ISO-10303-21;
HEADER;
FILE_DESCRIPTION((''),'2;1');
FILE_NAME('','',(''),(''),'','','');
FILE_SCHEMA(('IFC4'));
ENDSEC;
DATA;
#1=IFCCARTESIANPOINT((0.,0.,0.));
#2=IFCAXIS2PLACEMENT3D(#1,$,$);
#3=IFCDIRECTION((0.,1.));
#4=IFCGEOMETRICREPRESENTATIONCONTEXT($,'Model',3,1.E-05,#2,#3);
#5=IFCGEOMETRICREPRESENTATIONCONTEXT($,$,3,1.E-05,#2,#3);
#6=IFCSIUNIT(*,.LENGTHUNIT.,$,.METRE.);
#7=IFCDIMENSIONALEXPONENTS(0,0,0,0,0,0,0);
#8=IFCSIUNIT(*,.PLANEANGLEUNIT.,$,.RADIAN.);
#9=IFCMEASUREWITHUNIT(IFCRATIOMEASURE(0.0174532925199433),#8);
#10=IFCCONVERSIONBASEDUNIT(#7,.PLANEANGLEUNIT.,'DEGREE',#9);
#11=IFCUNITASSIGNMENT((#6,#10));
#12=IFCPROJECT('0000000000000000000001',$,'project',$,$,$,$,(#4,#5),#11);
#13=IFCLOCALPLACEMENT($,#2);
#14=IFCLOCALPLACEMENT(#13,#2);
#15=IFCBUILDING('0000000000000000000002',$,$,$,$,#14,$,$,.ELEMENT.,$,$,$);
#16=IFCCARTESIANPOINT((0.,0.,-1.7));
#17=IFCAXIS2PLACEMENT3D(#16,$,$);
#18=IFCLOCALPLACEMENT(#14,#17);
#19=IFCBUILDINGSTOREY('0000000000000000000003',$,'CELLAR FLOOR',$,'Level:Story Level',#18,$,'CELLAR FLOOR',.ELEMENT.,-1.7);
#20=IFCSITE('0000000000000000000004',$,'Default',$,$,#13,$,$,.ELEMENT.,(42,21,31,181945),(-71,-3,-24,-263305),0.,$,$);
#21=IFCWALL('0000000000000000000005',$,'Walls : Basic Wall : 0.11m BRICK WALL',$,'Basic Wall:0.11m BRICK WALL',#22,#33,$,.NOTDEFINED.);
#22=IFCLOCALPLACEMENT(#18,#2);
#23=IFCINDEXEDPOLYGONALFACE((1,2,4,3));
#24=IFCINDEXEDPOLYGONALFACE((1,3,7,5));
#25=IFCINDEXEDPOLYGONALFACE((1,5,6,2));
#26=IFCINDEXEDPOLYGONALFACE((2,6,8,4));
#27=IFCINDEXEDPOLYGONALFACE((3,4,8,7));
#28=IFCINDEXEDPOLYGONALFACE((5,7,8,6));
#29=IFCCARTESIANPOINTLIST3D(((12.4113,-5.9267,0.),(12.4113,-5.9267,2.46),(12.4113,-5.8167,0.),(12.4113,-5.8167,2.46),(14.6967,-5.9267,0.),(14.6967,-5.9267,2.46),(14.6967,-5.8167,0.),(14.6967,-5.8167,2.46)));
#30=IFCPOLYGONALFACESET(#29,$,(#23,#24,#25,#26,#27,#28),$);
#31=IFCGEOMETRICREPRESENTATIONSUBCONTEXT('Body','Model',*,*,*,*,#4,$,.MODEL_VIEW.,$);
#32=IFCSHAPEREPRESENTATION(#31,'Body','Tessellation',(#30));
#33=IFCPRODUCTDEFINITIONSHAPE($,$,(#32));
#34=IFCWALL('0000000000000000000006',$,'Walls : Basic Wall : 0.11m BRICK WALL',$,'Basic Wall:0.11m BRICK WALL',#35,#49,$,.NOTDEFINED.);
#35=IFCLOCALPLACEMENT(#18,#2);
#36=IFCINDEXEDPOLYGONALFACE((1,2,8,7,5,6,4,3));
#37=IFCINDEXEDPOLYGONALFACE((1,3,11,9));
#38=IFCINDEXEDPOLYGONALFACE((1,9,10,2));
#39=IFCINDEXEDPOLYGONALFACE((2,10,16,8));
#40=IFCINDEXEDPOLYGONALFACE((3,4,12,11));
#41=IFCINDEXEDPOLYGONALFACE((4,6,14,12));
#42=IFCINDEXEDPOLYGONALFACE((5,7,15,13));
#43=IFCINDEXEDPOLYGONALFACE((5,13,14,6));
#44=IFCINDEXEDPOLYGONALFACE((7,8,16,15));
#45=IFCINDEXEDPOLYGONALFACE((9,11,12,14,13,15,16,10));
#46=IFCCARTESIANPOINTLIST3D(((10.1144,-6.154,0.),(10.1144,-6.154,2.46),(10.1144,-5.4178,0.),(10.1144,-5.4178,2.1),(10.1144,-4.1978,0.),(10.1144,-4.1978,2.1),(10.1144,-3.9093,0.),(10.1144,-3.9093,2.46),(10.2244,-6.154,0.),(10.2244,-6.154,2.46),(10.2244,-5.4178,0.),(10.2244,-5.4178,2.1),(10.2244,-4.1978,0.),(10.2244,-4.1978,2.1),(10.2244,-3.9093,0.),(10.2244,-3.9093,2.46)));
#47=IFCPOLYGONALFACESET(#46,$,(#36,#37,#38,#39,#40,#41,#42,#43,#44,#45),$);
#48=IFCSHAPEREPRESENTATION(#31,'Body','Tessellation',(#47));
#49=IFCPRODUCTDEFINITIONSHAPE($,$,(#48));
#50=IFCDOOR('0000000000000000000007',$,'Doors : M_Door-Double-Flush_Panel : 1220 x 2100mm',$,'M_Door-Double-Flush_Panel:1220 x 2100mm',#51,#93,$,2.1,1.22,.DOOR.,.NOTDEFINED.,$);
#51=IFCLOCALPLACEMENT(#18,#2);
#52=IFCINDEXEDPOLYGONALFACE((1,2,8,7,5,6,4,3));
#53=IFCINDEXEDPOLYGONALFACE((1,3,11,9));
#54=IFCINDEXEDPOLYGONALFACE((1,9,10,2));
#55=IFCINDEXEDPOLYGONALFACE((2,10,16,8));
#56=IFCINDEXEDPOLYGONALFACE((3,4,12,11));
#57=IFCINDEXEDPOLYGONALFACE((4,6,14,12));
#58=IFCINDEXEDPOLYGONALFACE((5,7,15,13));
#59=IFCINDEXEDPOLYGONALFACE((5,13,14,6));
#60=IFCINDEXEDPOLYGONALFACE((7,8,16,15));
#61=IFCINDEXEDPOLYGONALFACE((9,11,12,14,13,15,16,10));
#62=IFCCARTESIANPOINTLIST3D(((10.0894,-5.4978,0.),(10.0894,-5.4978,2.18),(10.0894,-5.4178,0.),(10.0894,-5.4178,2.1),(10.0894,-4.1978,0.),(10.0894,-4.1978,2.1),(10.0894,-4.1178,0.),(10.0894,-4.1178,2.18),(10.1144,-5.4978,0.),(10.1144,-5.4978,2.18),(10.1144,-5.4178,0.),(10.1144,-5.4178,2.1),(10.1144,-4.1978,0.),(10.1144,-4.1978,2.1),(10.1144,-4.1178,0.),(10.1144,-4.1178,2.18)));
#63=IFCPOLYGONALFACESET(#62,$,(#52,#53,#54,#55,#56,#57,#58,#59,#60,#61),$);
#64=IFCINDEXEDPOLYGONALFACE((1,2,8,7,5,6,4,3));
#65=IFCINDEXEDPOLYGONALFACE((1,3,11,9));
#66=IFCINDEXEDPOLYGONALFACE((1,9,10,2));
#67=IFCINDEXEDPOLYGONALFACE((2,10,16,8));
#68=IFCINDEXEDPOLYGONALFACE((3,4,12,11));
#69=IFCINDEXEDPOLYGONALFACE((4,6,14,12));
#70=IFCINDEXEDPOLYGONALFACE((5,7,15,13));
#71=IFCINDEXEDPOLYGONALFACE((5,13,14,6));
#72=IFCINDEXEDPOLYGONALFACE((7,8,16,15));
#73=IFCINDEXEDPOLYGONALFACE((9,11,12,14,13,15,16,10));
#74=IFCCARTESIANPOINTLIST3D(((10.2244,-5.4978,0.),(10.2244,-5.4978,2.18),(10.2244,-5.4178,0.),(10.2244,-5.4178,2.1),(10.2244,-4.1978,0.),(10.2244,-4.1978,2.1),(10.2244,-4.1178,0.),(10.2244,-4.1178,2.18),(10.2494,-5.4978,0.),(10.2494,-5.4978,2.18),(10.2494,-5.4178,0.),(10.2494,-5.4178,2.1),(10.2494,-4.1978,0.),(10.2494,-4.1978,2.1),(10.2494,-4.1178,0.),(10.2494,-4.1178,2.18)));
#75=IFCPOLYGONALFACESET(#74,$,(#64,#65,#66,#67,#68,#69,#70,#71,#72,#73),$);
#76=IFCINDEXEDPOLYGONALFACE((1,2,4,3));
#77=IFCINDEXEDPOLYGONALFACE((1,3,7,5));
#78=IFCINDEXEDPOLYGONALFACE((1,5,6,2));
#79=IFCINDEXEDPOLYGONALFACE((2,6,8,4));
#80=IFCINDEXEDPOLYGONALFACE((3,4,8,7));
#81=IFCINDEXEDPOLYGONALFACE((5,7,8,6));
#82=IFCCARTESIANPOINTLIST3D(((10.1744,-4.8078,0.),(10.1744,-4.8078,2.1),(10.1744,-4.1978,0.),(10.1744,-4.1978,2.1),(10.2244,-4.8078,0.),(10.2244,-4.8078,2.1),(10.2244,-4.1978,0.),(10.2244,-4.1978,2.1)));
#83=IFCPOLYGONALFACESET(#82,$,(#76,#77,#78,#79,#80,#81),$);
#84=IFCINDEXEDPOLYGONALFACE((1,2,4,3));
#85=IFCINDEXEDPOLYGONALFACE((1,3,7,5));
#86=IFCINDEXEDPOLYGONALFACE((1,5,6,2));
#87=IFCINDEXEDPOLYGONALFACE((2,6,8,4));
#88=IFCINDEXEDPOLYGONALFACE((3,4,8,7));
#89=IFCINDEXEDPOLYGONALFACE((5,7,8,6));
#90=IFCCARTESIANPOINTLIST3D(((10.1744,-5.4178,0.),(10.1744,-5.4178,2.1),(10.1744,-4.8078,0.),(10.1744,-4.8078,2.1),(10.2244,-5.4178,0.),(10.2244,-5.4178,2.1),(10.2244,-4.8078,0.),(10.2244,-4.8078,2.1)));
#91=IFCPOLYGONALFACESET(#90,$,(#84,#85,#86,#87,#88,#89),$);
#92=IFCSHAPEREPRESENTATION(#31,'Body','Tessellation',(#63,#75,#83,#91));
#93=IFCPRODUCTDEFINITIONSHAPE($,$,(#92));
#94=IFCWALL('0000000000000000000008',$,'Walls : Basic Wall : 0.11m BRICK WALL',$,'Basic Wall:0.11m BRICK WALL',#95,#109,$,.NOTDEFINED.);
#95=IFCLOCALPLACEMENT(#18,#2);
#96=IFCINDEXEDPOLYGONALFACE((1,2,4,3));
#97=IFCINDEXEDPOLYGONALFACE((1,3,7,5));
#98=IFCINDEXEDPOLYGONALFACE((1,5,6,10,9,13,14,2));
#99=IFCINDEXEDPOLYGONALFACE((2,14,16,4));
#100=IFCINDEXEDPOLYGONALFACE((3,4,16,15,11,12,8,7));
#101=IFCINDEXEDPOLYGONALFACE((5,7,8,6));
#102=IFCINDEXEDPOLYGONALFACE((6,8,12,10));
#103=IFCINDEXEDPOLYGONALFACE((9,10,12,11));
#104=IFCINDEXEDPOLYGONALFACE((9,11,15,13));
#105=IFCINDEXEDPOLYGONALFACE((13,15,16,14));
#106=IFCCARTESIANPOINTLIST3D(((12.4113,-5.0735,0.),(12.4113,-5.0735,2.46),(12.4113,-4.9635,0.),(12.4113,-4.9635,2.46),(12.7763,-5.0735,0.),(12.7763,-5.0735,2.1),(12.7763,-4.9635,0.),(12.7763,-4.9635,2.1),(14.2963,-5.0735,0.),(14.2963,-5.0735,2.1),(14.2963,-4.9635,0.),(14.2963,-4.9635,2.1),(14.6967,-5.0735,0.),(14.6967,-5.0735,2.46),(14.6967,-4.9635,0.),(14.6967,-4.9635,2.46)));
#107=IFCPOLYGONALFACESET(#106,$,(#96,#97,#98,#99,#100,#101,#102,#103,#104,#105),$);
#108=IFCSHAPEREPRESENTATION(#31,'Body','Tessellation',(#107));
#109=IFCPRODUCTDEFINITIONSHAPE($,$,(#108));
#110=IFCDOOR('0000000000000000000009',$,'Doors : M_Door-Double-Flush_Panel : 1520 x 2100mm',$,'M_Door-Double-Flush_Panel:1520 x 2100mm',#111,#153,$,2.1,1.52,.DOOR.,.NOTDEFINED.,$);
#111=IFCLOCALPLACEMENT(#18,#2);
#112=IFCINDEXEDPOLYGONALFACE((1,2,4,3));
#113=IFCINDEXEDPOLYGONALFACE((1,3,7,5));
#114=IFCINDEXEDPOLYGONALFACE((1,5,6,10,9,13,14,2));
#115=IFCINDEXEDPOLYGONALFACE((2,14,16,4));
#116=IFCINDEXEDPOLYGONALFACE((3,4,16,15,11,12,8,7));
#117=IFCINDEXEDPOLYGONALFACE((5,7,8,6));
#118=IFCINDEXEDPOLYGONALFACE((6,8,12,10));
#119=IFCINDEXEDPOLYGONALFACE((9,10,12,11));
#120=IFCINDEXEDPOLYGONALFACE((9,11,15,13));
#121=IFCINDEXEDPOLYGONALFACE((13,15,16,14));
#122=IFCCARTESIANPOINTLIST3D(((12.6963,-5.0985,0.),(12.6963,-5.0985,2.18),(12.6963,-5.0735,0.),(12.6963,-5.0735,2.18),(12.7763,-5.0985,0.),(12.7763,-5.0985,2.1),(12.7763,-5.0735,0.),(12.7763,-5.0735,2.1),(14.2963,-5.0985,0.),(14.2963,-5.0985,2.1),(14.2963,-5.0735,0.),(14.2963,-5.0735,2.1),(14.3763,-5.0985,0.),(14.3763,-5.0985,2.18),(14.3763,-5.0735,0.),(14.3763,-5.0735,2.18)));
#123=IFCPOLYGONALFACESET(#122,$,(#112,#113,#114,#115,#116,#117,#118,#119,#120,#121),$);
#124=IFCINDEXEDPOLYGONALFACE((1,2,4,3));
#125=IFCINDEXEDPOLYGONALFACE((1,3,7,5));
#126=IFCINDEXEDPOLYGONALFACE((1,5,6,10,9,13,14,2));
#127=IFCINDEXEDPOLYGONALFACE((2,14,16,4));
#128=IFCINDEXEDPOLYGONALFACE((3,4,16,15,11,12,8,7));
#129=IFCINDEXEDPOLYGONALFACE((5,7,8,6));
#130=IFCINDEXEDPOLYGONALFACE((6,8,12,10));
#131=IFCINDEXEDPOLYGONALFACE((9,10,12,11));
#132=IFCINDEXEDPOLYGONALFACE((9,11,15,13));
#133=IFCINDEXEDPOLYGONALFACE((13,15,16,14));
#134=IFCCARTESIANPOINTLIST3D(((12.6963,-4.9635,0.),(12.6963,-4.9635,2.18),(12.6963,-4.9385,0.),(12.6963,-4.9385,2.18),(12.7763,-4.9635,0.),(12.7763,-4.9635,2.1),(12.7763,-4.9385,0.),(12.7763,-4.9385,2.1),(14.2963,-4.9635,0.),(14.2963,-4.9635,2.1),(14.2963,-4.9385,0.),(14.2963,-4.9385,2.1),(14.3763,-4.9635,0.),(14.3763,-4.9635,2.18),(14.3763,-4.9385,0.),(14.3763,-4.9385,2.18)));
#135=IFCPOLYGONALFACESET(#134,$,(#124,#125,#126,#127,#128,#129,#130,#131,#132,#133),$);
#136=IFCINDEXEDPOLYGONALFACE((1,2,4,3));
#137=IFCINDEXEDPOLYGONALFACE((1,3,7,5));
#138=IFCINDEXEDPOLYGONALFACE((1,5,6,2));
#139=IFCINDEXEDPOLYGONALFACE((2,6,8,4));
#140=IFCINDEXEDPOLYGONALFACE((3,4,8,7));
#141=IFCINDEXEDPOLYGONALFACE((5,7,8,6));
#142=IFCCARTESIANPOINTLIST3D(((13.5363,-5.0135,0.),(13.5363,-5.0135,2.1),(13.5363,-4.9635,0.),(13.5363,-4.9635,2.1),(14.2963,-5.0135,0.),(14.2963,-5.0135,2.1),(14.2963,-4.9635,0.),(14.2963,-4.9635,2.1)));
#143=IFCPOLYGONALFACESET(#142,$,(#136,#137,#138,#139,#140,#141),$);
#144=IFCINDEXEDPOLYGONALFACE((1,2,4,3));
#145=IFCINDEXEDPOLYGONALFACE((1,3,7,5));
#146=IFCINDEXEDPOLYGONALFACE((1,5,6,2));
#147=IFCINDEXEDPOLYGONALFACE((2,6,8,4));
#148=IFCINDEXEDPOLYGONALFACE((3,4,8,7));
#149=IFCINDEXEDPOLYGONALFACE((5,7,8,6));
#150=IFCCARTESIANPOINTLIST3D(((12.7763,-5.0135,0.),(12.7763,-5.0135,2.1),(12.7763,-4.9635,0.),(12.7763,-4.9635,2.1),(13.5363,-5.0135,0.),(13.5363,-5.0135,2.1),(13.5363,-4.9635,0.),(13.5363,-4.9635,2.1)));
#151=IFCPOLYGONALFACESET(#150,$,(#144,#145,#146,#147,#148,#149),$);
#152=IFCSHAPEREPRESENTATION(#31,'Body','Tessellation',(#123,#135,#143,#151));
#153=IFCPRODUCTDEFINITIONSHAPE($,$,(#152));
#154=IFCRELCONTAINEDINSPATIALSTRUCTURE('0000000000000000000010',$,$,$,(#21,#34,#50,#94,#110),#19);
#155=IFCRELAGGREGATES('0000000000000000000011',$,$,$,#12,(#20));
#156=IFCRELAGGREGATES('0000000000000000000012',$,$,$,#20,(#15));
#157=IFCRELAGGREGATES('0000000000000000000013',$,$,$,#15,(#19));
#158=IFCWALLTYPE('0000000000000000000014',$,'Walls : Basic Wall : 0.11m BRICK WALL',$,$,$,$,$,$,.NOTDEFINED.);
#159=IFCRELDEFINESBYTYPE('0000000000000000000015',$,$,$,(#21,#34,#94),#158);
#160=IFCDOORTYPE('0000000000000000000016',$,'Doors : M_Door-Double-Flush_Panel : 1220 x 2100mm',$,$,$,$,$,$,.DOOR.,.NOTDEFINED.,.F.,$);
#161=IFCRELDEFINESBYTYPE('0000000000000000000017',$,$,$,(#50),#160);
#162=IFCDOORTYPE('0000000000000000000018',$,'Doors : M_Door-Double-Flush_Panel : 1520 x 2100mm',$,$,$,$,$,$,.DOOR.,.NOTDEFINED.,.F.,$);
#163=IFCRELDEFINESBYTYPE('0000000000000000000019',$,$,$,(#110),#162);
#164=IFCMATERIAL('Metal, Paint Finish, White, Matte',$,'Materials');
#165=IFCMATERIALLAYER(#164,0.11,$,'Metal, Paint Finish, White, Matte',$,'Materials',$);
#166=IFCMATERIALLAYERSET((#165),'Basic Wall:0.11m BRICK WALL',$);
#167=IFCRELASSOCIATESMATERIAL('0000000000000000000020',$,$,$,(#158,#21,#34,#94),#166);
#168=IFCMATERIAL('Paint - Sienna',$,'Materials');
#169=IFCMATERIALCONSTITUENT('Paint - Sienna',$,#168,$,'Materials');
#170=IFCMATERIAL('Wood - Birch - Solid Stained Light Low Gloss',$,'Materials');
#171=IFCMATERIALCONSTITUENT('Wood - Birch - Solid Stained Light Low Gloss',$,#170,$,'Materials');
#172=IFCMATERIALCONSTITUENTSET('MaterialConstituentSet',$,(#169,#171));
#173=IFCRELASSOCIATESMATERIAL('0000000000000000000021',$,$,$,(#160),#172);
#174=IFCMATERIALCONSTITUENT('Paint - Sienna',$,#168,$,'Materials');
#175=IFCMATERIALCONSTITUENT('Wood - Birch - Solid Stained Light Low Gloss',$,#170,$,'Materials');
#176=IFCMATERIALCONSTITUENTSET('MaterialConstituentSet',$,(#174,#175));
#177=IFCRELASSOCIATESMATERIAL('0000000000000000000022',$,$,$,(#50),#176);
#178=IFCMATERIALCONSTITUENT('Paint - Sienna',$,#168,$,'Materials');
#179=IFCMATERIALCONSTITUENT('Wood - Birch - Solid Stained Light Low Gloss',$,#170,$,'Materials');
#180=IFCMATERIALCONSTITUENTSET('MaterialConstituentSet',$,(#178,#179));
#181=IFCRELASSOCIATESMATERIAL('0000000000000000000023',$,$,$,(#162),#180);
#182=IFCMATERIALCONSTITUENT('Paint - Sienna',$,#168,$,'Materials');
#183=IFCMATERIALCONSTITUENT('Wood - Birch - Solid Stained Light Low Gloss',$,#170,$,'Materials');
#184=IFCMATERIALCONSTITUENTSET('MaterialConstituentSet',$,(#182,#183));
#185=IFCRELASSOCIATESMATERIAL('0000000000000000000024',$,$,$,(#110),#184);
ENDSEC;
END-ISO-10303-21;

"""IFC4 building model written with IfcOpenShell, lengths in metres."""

from ifc_helpers import new_model, entity, si_unit, converted_unit, direction, frame, frame_2d, origin, origin_2d_with_axis, place, context, subcontext, project, spatial, polyline, rectangle, outline, extrude, source, transform, mapped, material, layer, layer_set, layer_usage, constituent, constituent_set, type_object, type_shapes, element, fill, save


model = new_model("IFC4")

# Units and contexts
model_context = context("Model", 3, precision=1e-05, world=origin(), true_north=direction((0.0, 1.0)))
context_of_model = context(None, 3, precision=1e-05, world=origin(), true_north=direction((0.0, 1.0)))
body_context = subcontext(model_context, "Body", "Model", "MODEL_VIEW")
ifc_project = project(units=[si_unit("LENGTHUNIT", "METRE"), converted_unit("PLANEANGLEUNIT", "DEGREE", entity("IfcRatioMeasure", 0.0174532925199433), si_unit("PLANEANGLEUNIT", "RADIAN"), dimensions=[0, 0, 0, 0, 0, 0, 0])], contexts=[model_context, context_of_model])

# Site, building, storey
site_placement = place(None, origin())
site = spatial("IfcSite", under=ifc_project, at=site_placement, Name="Default", CompositionType="ELEMENT", RefLatitude=(42, 21, 31, 181945), RefLongitude=(-71, -3, -24, -263305), RefElevation=0.0)
building_placement = place(site_placement, origin())
building = spatial("IfcBuilding", under=site, at=building_placement, CompositionType="ELEMENT")
storey_placement = place(building_placement, frame((0.0, 0.0, -1.7)))
storey = spatial("IfcBuildingStorey", under=building, at=storey_placement, Name="CELLAR FLOOR", ObjectType="Level:Story Level", LongName="CELLAR FLOOR", CompositionType="ELEMENT", Elevation=-1.7)

# Shared definitions
ifc_material_1 = material(Name="Metal, Paint Finish, White, Matte", Category="Materials")

# Shared definitions
ifc_layer_1 = layer(ifc_material_1, 0.11, Name="Metal, Paint Finish, White, Matte", Category="Materials")
ifc_layer_set_1 = layer_set([ifc_layer_1], Name="Basic Wall:0.11m BRICK WALL")
wall_type_1 = type_object("IfcWallType", Name="Walls : Basic Wall : 0.11m BRICK WALL", PredefinedType="NOTDEFINED", material=ifc_layer_set_1)
ifc_material_2 = material(Name="Paint - Sienna", Category="Materials")
ifc_material_3 = material(Name="Wood - Birch - Solid Stained Light Low Gloss", Category="Materials")
ifc_constituent_1 = constituent(ifc_material_2, Name="Paint - Sienna", Category="Materials")
ifc_constituent_2 = constituent(ifc_material_3, Name="Wood - Birch - Solid Stained Light Low Gloss", Category="Materials")
ifc_constituent_set_1 = constituent_set(constituents=[ifc_constituent_1, ifc_constituent_2], Name="MaterialConstituentSet")
door_type_1 = type_object("IfcDoorType", Name="Doors : M_Door-Double-Flush_Panel : 1220 x 2100mm", OperationType="NOTDEFINED", ParameterTakesPrecedence=False, PredefinedType="DOOR", material=ifc_constituent_set_1)
shared_shape_1 = source(origin(), body_context, "Body", "SweptSolid", [
    extrude(outline(polyline([(-1.03, 0.61), (1.07, 0.61), (1.07, 0.69), (-1.11, 0.69), (-1.11, -0.69), (1.07, -0.69), (1.07, -0.61), (-1.03, -0.61), (-1.03, 0.61)])), frame((0.61, 0.0, 1.07), z_axis=(0.0, -1.0, 0.0), x_axis=(0.0, 0.0, -1.0)), (0.0, 0.0, 1.0), 0.025),
    extrude(outline(polyline([(-1.03, 0.61), (1.07, 0.61), (1.07, 0.69), (-1.11, 0.69), (-1.11, -0.69), (1.07, -0.69), (1.07, -0.61), (-1.03, -0.61), (-1.03, 0.61)])), frame((0.61, 0.135, 1.07), z_axis=(0.0, -1.0, 0.0), x_axis=(0.0, 0.0, -1.0)), (0.0, 0.0, 1.0), 0.025),
    extrude(rectangle(XDim=0.61, YDim=0.05, at=origin_2d_with_axis()), frame((0.305, 0.085, 0.0), z_axis=(0.0, 0.0, 1.0), x_axis=(-1.0, 0.0, 0.0)), (0.0, 0.0, 1.0), 2.1),
    extrude(rectangle(XDim=0.61, YDim=0.05, at=frame_2d((0.0, 0.0), x_axis=(1.0, 0.0))), frame((0.915, 0.085, 0.0), z_axis=(0.0, 0.0, 1.0), x_axis=(-1.0, 0.0, 0.0)), (0.0, 0.0, 1.0), 2.1),
])
type_shapes(door_type_1, [shared_shape_1])

# Wall
ifc_layer_usage_1 = layer_usage(ifc_layer_set_1, "AXIS2", "NEGATIVE", 0.055)
wall_1_placement = place(storey_placement, frame((14.6967, -5.8717, 0.0), z_axis=(0.0, 0.0, 1.0), x_axis=(-1.0, 0.0, 0.0)))
element("IfcWall", 1, at=wall_1_placement, inside=storey, type_object=wall_type_1, material=ifc_layer_usage_1, Name="Walls : Basic Wall : 0.11m BRICK WALL", ObjectType="Basic Wall:0.11m BRICK WALL", PredefinedType="NOTDEFINED", context=body_context, shape_type="SweptSolid", body=[
    extrude(rectangle(XDim=2.2854, YDim=0.11, at=frame_2d((1.1427, 0.0), x_axis=(-1.0, 0.0))), origin(), (0.0, 0.0, 1.0), 2.46),
])

# Walls, openings, doors
ifc_layer_usage_2 = layer_usage(ifc_layer_set_1, "AXIS2", "NEGATIVE", 0.055)
wall_2_placement = place(storey_placement, frame((10.1694, -3.9093, 0.0), z_axis=(0.0, 0.0, 1.0), x_axis=(0.0, -1.0, 0.0)))
wall_2 = element("IfcWall", 2, at=wall_2_placement, inside=storey, type_object=wall_type_1, material=ifc_layer_usage_2, Name="Walls : Basic Wall : 0.11m BRICK WALL", ObjectType="Basic Wall:0.11m BRICK WALL", PredefinedType="NOTDEFINED", context=body_context, shape_type="SweptSolid", body=[
    extrude(rectangle(XDim=2.2447, YDim=0.11, at=frame_2d((1.1223, 0.0), x_axis=(-1.0, 0.0))), origin(), (0.0, 0.0, 1.0), 2.46),
])
opening_1_placement = place(wall_2_placement, frame((0.2885, -0.055, 0.0)))
opening_1 = element("IfcOpeningElement", 3, at=opening_1_placement, cuts=wall_2, ObjectType="Opening", PredefinedType="OPENING", context=body_context, shape_type="SweptSolid", body=[
    extrude(rectangle(XDim=2.1, YDim=1.22, at=frame_2d((1.05, 0.61), x_axis=(1.0, 0.0))), frame((0.0, 0.0, 0.0), z_axis=(0.0, 1.0, 0.0), x_axis=(0.0, 0.0, 1.0)), (0.0, 0.0, 1.0), 0.11),
])
ifc_constituent_3 = constituent(ifc_material_2, Name="Paint - Sienna", Category="Materials")
ifc_constituent_4 = constituent(ifc_material_3, Name="Wood - Birch - Solid Stained Light Low Gloss", Category="Materials")
ifc_constituent_set_2 = constituent_set(constituents=[ifc_constituent_3, ifc_constituent_4], Name="MaterialConstituentSet")
door_1_placement = place(opening_1_placement, origin())
door_1 = element("IfcDoor", 4, at=door_1_placement, inside=storey, type_object=door_type_1, material=ifc_constituent_set_2, Name="Doors : M_Door-Double-Flush_Panel : 1220 x 2100mm", ObjectType="M_Door-Double-Flush_Panel:1220 x 2100mm", OperationType="NOTDEFINED", OverallHeight=2.1, OverallWidth=1.22, PredefinedType="DOOR", context=body_context, shape_type="MappedRepresentation", body=[
    mapped(shared_shape_1, transform((0.0, 0.0, 0.0), scale=1.0)),
])
fill(opening_1, door_1)
ifc_layer_usage_3 = layer_usage(ifc_layer_set_1, "AXIS2", "NEGATIVE", 0.055)
wall_3_placement = place(storey_placement, frame((12.4113, -5.0185, 0.0)))
wall_3 = element("IfcWall", 5, at=wall_3_placement, inside=storey, type_object=wall_type_1, material=ifc_layer_usage_3, Name="Walls : Basic Wall : 0.11m BRICK WALL", ObjectType="Basic Wall:0.11m BRICK WALL", PredefinedType="NOTDEFINED", context=body_context, shape_type="SweptSolid", body=[
    extrude(rectangle(XDim=2.2854, YDim=0.11, at=frame_2d((1.1427, 0.0), x_axis=(-1.0, 0.0))), origin(), (0.0, 0.0, 1.0), 2.46),
])
opening_2_placement = place(wall_3_placement, frame((0.365, -0.055, 0.0)))
opening_2 = element("IfcOpeningElement", 6, at=opening_2_placement, cuts=wall_3, ObjectType="Opening", PredefinedType="OPENING", context=body_context, shape_type="SweptSolid", body=[
    extrude(rectangle(XDim=2.1, YDim=1.52, at=frame_2d((1.05, 0.76), x_axis=(1.0, 0.0))), frame((0.0, 0.0, 0.0), z_axis=(0.0, 1.0, 0.0), x_axis=(0.0, 0.0, 1.0)), (0.0, 0.0, 1.0), 0.11),
])
ifc_constituent_5 = constituent(ifc_material_2, Name="Paint - Sienna", Category="Materials")
ifc_constituent_6 = constituent(ifc_material_3, Name="Wood - Birch - Solid Stained Light Low Gloss", Category="Materials")
ifc_constituent_set_3 = constituent_set(constituents=[ifc_constituent_5, ifc_constituent_6], Name="MaterialConstituentSet")
ifc_constituent_7 = constituent(ifc_material_2, Name="Paint - Sienna", Category="Materials")
ifc_constituent_8 = constituent(ifc_material_3, Name="Wood - Birch - Solid Stained Light Low Gloss", Category="Materials")
ifc_constituent_set_4 = constituent_set(constituents=[ifc_constituent_7, ifc_constituent_8], Name="MaterialConstituentSet")
door_type_2 = type_object("IfcDoorType", Name="Doors : M_Door-Double-Flush_Panel : 1520 x 2100mm", OperationType="NOTDEFINED", ParameterTakesPrecedence=False, PredefinedType="DOOR", material=ifc_constituent_set_4)
shared_shape_2 = source(origin(), body_context, "Body", "SweptSolid", [
    extrude(outline(polyline([(-1.03, 0.76), (1.07, 0.76), (1.07, 0.84), (-1.11, 0.84), (-1.11, -0.84), (1.07, -0.84), (1.07, -0.76), (-1.03, -0.76), (-1.03, 0.76)])), frame((0.76, -0.025, 1.07), z_axis=(0.0, 1.0, 0.0), x_axis=(0.0, 0.0, -1.0)), (0.0, 0.0, 1.0), 0.025),
    extrude(outline(polyline([(-1.03, 0.76), (1.07, 0.76), (1.07, 0.84), (-1.11, 0.84), (-1.11, -0.84), (1.07, -0.84), (1.07, -0.76), (-1.03, -0.76), (-1.03, 0.76)])), frame((0.76, 0.11, 1.07), z_axis=(0.0, 1.0, 0.0), x_axis=(0.0, 0.0, -1.0)), (0.0, 0.0, 1.0), 0.025),
    extrude(rectangle(XDim=0.05, YDim=0.76, at=origin_2d_with_axis()), frame((1.14, 0.085, 0.0), z_axis=(0.0, 0.0, 1.0), x_axis=(0.0, -1.0, 0.0)), (0.0, 0.0, 1.0), 2.1),
    extrude(rectangle(XDim=0.05, YDim=0.76, at=origin_2d_with_axis()), frame((0.38, 0.085, 0.0), z_axis=(0.0, 0.0, 1.0), x_axis=(0.0, -1.0, 0.0)), (0.0, 0.0, 1.0), 2.1),
])
type_shapes(door_type_2, [shared_shape_2])
door_2_placement = place(opening_2_placement, origin())
door_2 = element("IfcDoor", 7, at=door_2_placement, inside=storey, type_object=door_type_2, material=ifc_constituent_set_3, Name="Doors : M_Door-Double-Flush_Panel : 1520 x 2100mm", ObjectType="M_Door-Double-Flush_Panel:1520 x 2100mm", OperationType="NOTDEFINED", OverallHeight=2.1, OverallWidth=1.52, PredefinedType="DOOR", context=body_context, shape_type="MappedRepresentation", body=[
    mapped(shared_shape_2, transform((0.0, 0.0, 0.0), scale=1.0)),
])
fill(opening_2, door_2)

save(model, "model.ifc")
